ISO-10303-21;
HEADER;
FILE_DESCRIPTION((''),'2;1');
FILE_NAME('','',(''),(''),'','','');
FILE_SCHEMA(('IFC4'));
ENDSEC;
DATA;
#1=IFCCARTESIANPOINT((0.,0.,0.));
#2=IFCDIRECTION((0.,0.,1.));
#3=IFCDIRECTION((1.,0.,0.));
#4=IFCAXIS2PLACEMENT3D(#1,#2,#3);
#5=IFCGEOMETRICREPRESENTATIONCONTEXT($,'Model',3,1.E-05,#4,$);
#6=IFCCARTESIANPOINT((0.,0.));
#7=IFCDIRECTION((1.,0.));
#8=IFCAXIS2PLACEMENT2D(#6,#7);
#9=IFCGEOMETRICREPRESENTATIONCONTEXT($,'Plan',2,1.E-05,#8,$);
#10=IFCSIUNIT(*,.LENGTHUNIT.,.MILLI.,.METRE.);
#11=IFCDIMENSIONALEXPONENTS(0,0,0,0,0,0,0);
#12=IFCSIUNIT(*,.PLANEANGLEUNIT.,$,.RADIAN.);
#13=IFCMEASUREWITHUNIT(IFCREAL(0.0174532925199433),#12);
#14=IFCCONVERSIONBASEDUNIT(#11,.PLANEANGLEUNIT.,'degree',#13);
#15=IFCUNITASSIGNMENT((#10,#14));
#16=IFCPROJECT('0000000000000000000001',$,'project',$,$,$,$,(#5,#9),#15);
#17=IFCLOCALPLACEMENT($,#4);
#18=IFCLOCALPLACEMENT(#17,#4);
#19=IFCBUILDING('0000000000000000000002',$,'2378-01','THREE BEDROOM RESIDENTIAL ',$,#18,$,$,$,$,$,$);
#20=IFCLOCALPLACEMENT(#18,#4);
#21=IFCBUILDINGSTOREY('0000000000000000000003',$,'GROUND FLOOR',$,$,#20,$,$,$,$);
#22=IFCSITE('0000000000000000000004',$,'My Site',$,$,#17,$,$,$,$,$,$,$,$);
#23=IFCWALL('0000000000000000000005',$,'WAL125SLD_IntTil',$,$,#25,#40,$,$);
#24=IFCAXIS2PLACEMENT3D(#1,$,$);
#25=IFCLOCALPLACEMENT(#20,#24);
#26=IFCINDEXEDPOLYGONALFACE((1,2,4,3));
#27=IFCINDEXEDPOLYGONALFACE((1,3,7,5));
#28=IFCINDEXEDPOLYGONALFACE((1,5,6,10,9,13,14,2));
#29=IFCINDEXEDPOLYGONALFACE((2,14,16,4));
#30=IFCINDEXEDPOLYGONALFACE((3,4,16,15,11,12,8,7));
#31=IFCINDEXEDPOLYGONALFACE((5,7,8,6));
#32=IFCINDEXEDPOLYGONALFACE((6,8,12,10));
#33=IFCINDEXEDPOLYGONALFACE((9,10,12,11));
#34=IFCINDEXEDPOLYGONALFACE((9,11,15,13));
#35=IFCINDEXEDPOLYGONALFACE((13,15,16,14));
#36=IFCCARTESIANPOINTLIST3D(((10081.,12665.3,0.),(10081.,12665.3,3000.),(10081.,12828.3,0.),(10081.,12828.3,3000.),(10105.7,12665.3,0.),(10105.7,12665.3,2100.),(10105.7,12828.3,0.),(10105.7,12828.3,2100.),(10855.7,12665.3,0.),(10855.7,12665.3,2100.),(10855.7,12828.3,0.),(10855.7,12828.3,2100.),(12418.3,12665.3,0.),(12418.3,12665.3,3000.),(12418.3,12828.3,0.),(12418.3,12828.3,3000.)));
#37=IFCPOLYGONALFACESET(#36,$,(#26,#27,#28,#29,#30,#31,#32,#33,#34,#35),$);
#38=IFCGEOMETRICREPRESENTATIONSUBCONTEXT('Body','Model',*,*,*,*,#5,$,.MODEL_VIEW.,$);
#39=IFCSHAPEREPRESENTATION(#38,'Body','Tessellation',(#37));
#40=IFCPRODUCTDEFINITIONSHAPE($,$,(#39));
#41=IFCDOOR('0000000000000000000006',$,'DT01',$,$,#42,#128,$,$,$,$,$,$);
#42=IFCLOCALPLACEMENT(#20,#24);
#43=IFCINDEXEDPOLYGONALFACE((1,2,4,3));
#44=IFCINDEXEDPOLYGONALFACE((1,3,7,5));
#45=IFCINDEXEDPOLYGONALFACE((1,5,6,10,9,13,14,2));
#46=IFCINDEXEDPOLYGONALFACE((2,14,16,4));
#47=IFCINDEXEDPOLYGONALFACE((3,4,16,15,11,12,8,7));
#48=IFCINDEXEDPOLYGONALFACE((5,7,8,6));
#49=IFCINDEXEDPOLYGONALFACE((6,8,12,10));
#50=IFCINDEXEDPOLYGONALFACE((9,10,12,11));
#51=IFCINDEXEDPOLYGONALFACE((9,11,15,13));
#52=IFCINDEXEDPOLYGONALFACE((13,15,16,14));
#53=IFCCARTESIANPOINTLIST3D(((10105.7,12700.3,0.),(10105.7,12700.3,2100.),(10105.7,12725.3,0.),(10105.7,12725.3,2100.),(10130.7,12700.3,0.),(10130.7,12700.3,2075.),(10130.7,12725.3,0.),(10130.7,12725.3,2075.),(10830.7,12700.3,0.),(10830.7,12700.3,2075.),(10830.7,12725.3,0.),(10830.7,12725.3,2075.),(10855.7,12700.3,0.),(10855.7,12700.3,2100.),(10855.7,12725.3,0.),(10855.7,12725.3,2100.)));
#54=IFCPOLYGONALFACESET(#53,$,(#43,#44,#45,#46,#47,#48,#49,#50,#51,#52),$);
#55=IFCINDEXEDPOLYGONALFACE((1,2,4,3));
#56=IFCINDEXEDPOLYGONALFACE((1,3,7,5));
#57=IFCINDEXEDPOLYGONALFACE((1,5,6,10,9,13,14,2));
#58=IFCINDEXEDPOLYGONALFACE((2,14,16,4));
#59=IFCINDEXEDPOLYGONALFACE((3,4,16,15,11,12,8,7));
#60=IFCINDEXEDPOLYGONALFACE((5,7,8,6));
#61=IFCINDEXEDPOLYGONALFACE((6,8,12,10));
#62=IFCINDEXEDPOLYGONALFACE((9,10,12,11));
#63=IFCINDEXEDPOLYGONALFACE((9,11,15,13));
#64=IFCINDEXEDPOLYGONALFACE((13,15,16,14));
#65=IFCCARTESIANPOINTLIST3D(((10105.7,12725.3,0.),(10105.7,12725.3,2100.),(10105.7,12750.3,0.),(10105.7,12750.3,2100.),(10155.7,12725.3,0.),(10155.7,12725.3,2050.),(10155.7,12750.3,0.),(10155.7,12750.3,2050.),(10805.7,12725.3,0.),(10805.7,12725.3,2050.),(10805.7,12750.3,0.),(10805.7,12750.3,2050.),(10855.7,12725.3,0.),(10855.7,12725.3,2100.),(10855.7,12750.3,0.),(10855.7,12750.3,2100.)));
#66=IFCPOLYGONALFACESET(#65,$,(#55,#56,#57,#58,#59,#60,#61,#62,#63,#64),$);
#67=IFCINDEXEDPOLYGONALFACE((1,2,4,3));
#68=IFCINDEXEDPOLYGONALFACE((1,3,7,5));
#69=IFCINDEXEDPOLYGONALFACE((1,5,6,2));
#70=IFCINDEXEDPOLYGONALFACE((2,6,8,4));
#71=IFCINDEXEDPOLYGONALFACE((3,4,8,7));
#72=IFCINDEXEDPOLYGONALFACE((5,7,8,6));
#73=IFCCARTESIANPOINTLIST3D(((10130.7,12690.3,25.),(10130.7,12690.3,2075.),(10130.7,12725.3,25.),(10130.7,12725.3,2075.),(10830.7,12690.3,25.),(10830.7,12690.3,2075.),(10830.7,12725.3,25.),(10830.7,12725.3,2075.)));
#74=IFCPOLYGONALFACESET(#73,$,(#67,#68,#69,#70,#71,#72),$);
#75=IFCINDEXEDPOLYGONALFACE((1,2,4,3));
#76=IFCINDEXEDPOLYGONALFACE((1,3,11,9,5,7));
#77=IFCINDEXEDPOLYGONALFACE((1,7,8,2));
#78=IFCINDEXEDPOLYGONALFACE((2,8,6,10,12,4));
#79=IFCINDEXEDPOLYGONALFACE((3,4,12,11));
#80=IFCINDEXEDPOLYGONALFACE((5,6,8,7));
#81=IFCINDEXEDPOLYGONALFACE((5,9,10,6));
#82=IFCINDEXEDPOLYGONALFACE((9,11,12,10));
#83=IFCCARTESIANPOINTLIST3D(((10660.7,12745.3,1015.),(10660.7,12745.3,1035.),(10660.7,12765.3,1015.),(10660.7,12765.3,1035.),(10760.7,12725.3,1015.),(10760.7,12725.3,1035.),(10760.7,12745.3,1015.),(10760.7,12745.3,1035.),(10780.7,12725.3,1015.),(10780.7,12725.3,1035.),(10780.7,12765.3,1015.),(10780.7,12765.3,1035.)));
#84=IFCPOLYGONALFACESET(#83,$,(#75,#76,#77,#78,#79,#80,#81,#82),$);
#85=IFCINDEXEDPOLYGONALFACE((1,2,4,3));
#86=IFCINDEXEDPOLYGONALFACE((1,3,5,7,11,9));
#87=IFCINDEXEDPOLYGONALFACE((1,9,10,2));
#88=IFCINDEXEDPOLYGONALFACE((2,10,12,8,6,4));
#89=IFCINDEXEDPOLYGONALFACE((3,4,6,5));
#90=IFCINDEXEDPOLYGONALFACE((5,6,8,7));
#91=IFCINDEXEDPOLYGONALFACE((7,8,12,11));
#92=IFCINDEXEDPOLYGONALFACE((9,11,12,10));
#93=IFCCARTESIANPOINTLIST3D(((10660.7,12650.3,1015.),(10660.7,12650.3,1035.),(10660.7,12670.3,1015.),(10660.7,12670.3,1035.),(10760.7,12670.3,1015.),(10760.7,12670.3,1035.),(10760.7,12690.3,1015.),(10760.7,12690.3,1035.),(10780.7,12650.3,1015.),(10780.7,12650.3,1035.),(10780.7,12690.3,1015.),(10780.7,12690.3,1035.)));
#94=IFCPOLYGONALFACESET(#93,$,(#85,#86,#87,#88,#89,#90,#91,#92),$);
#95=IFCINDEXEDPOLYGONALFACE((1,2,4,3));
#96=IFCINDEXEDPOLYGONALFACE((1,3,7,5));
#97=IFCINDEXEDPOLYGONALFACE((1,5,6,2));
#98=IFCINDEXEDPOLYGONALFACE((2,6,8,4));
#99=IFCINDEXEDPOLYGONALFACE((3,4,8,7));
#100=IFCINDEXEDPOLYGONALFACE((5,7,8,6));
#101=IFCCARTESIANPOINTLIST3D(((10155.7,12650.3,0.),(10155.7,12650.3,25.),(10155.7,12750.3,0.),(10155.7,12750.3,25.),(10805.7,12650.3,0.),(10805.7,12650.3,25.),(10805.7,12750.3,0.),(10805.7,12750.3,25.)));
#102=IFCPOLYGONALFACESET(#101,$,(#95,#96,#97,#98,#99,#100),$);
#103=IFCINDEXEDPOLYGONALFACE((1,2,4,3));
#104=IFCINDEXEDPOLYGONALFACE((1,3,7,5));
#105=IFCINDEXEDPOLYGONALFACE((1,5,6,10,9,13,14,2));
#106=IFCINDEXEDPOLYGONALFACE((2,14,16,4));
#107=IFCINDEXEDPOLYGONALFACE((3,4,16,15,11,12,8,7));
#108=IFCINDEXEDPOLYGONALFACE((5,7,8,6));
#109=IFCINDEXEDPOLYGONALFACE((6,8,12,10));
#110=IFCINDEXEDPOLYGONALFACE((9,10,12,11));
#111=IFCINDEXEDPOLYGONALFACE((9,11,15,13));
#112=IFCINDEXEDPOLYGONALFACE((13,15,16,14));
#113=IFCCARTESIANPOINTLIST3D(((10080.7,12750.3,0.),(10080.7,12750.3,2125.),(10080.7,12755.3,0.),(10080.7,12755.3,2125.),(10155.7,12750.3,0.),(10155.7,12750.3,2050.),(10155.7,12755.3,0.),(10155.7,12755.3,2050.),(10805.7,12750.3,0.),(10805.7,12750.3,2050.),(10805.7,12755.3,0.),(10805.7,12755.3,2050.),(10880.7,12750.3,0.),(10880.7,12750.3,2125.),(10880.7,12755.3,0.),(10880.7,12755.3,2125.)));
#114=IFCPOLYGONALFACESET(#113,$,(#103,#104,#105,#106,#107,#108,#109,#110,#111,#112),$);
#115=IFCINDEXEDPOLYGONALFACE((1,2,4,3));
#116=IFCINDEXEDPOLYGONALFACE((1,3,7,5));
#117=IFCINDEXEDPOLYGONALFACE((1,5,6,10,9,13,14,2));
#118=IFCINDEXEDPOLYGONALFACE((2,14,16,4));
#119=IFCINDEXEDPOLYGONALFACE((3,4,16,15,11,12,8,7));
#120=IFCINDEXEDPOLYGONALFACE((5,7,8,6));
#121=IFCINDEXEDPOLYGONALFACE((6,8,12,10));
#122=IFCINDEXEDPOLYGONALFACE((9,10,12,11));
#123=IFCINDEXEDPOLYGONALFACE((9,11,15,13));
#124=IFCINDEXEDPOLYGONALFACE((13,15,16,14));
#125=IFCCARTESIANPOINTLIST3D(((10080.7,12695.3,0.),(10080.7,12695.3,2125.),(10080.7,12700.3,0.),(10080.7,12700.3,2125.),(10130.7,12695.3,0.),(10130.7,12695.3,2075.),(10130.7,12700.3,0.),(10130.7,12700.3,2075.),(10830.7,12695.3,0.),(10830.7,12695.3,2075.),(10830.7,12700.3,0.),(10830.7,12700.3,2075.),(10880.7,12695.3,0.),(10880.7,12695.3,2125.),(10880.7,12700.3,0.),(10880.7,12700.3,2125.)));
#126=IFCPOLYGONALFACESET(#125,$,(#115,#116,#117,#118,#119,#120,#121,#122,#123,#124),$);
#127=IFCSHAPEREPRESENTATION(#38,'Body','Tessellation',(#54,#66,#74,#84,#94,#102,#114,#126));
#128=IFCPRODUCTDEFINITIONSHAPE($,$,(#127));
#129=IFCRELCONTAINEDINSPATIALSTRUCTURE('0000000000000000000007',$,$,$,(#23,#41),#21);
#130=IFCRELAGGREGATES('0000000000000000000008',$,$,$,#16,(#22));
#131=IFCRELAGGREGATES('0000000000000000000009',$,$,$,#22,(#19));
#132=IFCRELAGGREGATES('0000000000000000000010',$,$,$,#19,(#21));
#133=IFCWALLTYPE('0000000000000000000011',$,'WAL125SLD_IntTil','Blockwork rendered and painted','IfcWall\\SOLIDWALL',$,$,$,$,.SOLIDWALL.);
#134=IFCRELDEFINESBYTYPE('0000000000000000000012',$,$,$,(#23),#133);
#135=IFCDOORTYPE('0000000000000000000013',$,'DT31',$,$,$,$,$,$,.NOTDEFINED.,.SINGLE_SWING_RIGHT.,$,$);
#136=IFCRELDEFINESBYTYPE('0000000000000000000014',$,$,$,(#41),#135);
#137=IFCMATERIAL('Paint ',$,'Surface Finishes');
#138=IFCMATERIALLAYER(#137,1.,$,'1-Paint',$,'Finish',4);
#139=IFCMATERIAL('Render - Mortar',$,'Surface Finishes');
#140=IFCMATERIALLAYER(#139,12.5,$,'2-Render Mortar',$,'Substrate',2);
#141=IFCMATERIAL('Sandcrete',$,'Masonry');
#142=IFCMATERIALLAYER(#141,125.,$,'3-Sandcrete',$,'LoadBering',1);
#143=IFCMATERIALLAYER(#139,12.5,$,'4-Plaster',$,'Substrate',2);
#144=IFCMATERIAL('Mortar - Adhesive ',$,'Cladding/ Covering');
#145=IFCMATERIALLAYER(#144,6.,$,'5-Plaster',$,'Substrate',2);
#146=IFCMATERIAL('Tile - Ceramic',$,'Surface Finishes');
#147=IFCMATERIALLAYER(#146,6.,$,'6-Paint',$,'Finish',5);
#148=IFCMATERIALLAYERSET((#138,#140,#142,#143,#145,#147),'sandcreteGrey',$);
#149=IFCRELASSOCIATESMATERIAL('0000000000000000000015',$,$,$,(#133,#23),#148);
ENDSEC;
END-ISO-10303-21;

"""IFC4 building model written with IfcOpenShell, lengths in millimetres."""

from ifc_helpers import new_model, entity, si_unit, converted_unit, frame, origin_with_axes, origin_2d_with_axis, place, context, subcontext, project, spatial, line, indexed_curve, outline, extrude, shape, source, transform, mapped, material, layer, layer_set, layer_usage, type_object, type_shapes, element, fill, save


model = new_model("IFC4")

# Units and contexts
model_context = context("Model", 3, precision=1e-05, world=origin_with_axes())
plan_context = context("Plan", 2, precision=1e-05, world=origin_2d_with_axis())
body_context_1 = subcontext(model_context, "Body", "Model", "MODEL_VIEW")
body_context_2 = subcontext(plan_context, "Body", "Plan", "PLAN_VIEW")
ifc_project = project(units=[si_unit("LENGTHUNIT", "METRE", prefix="MILLI"), converted_unit("PLANEANGLEUNIT", "degree", entity("IfcReal", 0.0174532925199433), si_unit("PLANEANGLEUNIT", "RADIAN"), dimensions=[0, 0, 0, 0, 0, 0, 0])], contexts=[model_context, plan_context])

# Site, building, storey
site_placement = place(None, origin_with_axes())
site = spatial("IfcSite", under=ifc_project, at=site_placement, Name="My Site")
building_placement = place(site_placement, origin_with_axes())
building = spatial("IfcBuilding", under=site, at=building_placement, Name="2378-01", Description="THREE BEDROOM RESIDENTIAL ")
storey_placement = place(building_placement, origin_with_axes())
storey = spatial("IfcBuildingStorey", under=building, at=storey_placement, Name="GROUND FLOOR")

# Shared definitions
ifc_material_1 = material(Name="Paint ", Category="Surface Finishes")
ifc_material_2 = material(Name="Render - Mortar", Category="Surface Finishes")
ifc_material_3 = material(Name="Sandcrete", Category="Masonry")

# Shared definitions
ifc_material_4 = material(Name="Tile - Ceramic", Category="Surface Finishes")
ifc_material_5 = material(Name="Mortar - Adhesive ", Category="Cladding/ Covering")

# Shared definitions
ifc_layer_1 = layer(ifc_material_1, 1.0, Name="1-Paint", Category="Finish", Priority=4)
ifc_layer_2 = layer(ifc_material_2, 12.5, Name="2-Render Mortar", Category="Substrate", Priority=2)
ifc_layer_3 = layer(ifc_material_3, 125.0, Name="3-Sandcrete", Category="LoadBering", Priority=1)
ifc_layer_4 = layer(ifc_material_2, 12.5, Name="4-Plaster", Category="Substrate", Priority=2)
ifc_layer_5 = layer(ifc_material_5, 6.0, Name="5-Plaster", Category="Substrate", Priority=2)
ifc_layer_6 = layer(ifc_material_4, 6.0, Name="6-Paint", Category="Finish", Priority=5)
ifc_layer_set_1 = layer_set([ifc_layer_1, ifc_layer_2, ifc_layer_3, ifc_layer_4, ifc_layer_5, ifc_layer_6], Name="sandcreteGrey")
wall_type_1 = type_object("IfcWallType", Name="WAL125SLD_IntTil", Description="Blockwork rendered and painted", ApplicableOccurrence="IfcWall\\SOLIDWALL", PredefinedType="SOLIDWALL", material=ifc_layer_set_1)

# Wall, opening, door
ifc_layer_usage_1 = layer_usage(ifc_layer_set_1, "AXIS2", "POSITIVE", 0.0)
wall_1_placement = place(storey_placement, frame((10081.0, 12665.3, 0.0), z_axis=(0.0, 0.0, 1.0), x_axis=(1.0, -0.000001, 0.0)))
wall_1 = element("IfcWall", 1, at=wall_1_placement, inside=storey, type_object=wall_type_1, material=ifc_layer_usage_1, Name="WAL125SLD_IntTil", context=body_context_1, shape_type="SweptSolid", body=[
    extrude(outline(indexed_curve([(0.0, 0.0), (0.0, 163.0), (2337.3, 163.0), (2337.3, 0.0), (0.0, 0.0)], self_intersect=False)), origin_with_axes(), (0.0, 0.0, 1.0), 3000.0),
])
shared_shape_1 = source(origin_with_axes(), body_context_1, "Body", "SweptSolid", [
    extrude(outline(indexed_curve([(0.0, 0.0), (750.0, 0.0), (750.0, 2100.0), (0.0, 2100.0)], segments=[line(1, 2, 3, 4, 1)])), frame((0.0, -600.0, 0.0), z_axis=(0.0, -1.0, 0.0), x_axis=(1.0, 0.0, 0.0)), (0.0, 0.0, -1.0), 1200.0),
])
opening_1_placement = place(wall_1_placement, frame((774.7, 85.0, 0.0), z_axis=(0.0, 0.0, 1.0), x_axis=(-1.0, 0.0, 0.0)))
opening_1 = element("IfcOpeningElement", 2, at=opening_1_placement, cuts=wall_1, PredefinedType="OPENING", context=body_context_1, shape_type="MappedRepresentation", body=[
    mapped(shared_shape_1, transform((0.0, 0.0, 0.0), x_axis=(1.0, 0.0, 0.0), y_axis=(0.0, 1.0, 0.0), z_axis=(0.0, 0.0, 1.0), scale=1.0)),
])
door_type_1 = type_object("IfcDoorType", Name="DT31", OperationType="SINGLE_SWING_RIGHT", PredefinedType="NOTDEFINED")
shared_shape_2 = source(origin_with_axes(), body_context_1, "Body", "SweptSolid", [
    extrude(outline(indexed_curve([(0.0, 0.0), (0.0, 2100.0), (750.0, 2100.0), (750.0, 0.0), (725.0, 0.0), (725.0, 2075.0), (25.0, 2075.0), (25.0, 0.0)], segments=[line(1, 2, 3, 4, 5, 6, 7, 8, 1)])), frame((0.0, 25.0, 0.0), z_axis=(0.0, -1.0, 0.0), x_axis=(1.0, 0.0, 0.0)), (0.0, 0.0, -1.0), 25.0),
    extrude(outline(indexed_curve([(0.0, 0.0), (0.0, 2100.0), (750.0, 2100.0), (750.0, 0.0), (700.0, 0.0), (700.0, 2050.0), (50.0, 2050.0), (50.0, 0.0)], segments=[line(1, 2, 3, 4, 5, 6, 7, 8, 1)])), frame((0.0, 0.0, 0.0), z_axis=(0.0, -1.0, 0.0), x_axis=(1.0, 0.0, 0.0)), (0.0, 0.0, -1.0), 25.0),
    extrude(outline(indexed_curve([(0.0, 0.0), (700.0, 0.0), (700.0, 35.0), (0.0, 35.0)], segments=[line(1, 2, 3, 4, 1)])), frame((25.0, 25.0, 25.0), z_axis=(0.0, 0.0, 1.0), x_axis=(1.0, 0.0, 0.0)), (0.0, 0.0, 1.0), 2050.0),
    extrude(outline(indexed_curve([(0.0, 0.0), (0.0, -40.0), (120.0, -40.0), (120.0, -20.0), (20.0, -20.0), (20.0, 0.0)], segments=[line(1, 2, 3, 4, 5, 6, 1)])), frame((75.0, 25.0, 1015.0), z_axis=(0.0, 0.0, 1.0), x_axis=(1.0, 0.0, 0.0)), (0.0, 0.0, 1.0), 20.0),
    extrude(outline(indexed_curve([(0.0, 0.0), (0.0, 40.0), (120.0, 40.0), (120.0, 20.0), (20.0, 20.0), (20.0, 0.0)], segments=[line(1, 2, 3, 4, 5, 6, 1)])), frame((75.0, 60.0, 1015.0), z_axis=(0.0, 0.0, 1.0), x_axis=(1.0, 0.0, 0.0)), (0.0, 0.0, 1.0), 20.0),
    extrude(outline(indexed_curve([(0.0, 0.0), (650.0, 0.0), (650.0, 100.0), (0.0, 100.0)], segments=[line(1, 2, 3, 4, 1)])), frame((50.0, 0.0, 0.0), z_axis=(0.0, 0.0, 1.0), x_axis=(1.0, 0.0, 0.0)), (0.0, 0.0, 1.0), 25.0),
    extrude(outline(indexed_curve([(0.0, 0.0), (0.0, 2125.0), (800.0, 2125.0), (800.0, 0.0), (725.0, 0.0), (725.0, 2050.0), (75.0, 2050.0), (75.0, 0.0)], segments=[line(1, 2, 3, 4, 5, 6, 7, 8, 1)])), frame((-25.0, -5.0, 0.0), z_axis=(0.0, -1.0, 0.0), x_axis=(1.0, 0.0, 0.0)), (0.0, 0.0, -1.0), 5.0),
    extrude(outline(indexed_curve([(0.0, 0.0), (0.0, 2125.0), (800.0, 2125.0), (800.0, 0.0), (750.0, 0.0), (750.0, 2075.0), (50.0, 2075.0), (50.0, 0.0)], segments=[line(1, 2, 3, 4, 5, 6, 7, 8, 1)])), frame((-25.0, 50.0, 0.0), z_axis=(0.0, -1.0, 0.0), x_axis=(1.0, 0.0, 0.0)), (0.0, 0.0, -1.0), 5.0),
])
shared_shape_3 = source(origin_with_axes(), body_context_2, "Body", "Curve2D", [
    entity("IfcIndexedPolyCurve", entity("IfcCartesianPointList2D", [[0.0, 0.0], [0.0, 50.0], [25.0, 50.0], [25.0, 25.0], [50.0, 25.0], [50.0, 0.0]]), [entity("IfcLineIndex", [1, 2, 3, 4, 5, 6, 1])]),
    entity("IfcIndexedPolyCurve", entity("IfcCartesianPointList2D", [[750.0, 0.0], [750.0, 50.0], [725.0, 50.0], [725.0, 25.0], [700.0, 25.0], [700.0, 0.0]]), [entity("IfcLineIndex", [1, 2, 3, 4, 5, 6, 1])]),
    entity("IfcTrimmedCurve", entity("IfcEllipse", entity("IfcAxis2Placement2D", entity("IfcCartesianPoint", [690.0, 50.0]), entity("IfcDirection", [1.0, 0.0])), 665.0, 700.0), [entity("IfcCartesianPoint", [690.0, 750.0])], [entity("IfcCartesianPoint", [25.0, 50.0])], True, "CARTESIAN"),
    entity("IfcIndexedPolyCurve", entity("IfcCartesianPointList2D", [[725.0, 50.0], [690.0, 50.0], [690.0, 750.0], [725.0, 750.0]]), [entity("IfcLineIndex", [1, 2, 3, 4, 1])]),
])
type_shapes(door_type_1, [shared_shape_2, shared_shape_3])
door_1_placement = place(opening_1_placement, origin_with_axes())
door_1 = element("IfcDoor", 3, at=door_1_placement, inside=storey, type_object=door_type_1, Name="DT01", shapes=[
    shape(body_context_1, "Body", "MappedRepresentation", [mapped(shared_shape_2, transform((0.0, 0.0, 0.0), x_axis=(1.0, 0.0, 0.0), y_axis=(0.0, 1.0, 0.0), z_axis=(0.0, 0.0, 1.0), scale=1.0))]),
    shape(body_context_2, "Body", "MappedRepresentation", [mapped(shared_shape_3, transform((0.0, 0.0, 0.0), x_axis=(1.0, 0.0, 0.0), y_axis=(0.0, 1.0, 0.0), z_axis=(0.0, 0.0, 1.0), scale=1.0))]),
])
fill(opening_1, door_1)

save(model, "model.ifc")
